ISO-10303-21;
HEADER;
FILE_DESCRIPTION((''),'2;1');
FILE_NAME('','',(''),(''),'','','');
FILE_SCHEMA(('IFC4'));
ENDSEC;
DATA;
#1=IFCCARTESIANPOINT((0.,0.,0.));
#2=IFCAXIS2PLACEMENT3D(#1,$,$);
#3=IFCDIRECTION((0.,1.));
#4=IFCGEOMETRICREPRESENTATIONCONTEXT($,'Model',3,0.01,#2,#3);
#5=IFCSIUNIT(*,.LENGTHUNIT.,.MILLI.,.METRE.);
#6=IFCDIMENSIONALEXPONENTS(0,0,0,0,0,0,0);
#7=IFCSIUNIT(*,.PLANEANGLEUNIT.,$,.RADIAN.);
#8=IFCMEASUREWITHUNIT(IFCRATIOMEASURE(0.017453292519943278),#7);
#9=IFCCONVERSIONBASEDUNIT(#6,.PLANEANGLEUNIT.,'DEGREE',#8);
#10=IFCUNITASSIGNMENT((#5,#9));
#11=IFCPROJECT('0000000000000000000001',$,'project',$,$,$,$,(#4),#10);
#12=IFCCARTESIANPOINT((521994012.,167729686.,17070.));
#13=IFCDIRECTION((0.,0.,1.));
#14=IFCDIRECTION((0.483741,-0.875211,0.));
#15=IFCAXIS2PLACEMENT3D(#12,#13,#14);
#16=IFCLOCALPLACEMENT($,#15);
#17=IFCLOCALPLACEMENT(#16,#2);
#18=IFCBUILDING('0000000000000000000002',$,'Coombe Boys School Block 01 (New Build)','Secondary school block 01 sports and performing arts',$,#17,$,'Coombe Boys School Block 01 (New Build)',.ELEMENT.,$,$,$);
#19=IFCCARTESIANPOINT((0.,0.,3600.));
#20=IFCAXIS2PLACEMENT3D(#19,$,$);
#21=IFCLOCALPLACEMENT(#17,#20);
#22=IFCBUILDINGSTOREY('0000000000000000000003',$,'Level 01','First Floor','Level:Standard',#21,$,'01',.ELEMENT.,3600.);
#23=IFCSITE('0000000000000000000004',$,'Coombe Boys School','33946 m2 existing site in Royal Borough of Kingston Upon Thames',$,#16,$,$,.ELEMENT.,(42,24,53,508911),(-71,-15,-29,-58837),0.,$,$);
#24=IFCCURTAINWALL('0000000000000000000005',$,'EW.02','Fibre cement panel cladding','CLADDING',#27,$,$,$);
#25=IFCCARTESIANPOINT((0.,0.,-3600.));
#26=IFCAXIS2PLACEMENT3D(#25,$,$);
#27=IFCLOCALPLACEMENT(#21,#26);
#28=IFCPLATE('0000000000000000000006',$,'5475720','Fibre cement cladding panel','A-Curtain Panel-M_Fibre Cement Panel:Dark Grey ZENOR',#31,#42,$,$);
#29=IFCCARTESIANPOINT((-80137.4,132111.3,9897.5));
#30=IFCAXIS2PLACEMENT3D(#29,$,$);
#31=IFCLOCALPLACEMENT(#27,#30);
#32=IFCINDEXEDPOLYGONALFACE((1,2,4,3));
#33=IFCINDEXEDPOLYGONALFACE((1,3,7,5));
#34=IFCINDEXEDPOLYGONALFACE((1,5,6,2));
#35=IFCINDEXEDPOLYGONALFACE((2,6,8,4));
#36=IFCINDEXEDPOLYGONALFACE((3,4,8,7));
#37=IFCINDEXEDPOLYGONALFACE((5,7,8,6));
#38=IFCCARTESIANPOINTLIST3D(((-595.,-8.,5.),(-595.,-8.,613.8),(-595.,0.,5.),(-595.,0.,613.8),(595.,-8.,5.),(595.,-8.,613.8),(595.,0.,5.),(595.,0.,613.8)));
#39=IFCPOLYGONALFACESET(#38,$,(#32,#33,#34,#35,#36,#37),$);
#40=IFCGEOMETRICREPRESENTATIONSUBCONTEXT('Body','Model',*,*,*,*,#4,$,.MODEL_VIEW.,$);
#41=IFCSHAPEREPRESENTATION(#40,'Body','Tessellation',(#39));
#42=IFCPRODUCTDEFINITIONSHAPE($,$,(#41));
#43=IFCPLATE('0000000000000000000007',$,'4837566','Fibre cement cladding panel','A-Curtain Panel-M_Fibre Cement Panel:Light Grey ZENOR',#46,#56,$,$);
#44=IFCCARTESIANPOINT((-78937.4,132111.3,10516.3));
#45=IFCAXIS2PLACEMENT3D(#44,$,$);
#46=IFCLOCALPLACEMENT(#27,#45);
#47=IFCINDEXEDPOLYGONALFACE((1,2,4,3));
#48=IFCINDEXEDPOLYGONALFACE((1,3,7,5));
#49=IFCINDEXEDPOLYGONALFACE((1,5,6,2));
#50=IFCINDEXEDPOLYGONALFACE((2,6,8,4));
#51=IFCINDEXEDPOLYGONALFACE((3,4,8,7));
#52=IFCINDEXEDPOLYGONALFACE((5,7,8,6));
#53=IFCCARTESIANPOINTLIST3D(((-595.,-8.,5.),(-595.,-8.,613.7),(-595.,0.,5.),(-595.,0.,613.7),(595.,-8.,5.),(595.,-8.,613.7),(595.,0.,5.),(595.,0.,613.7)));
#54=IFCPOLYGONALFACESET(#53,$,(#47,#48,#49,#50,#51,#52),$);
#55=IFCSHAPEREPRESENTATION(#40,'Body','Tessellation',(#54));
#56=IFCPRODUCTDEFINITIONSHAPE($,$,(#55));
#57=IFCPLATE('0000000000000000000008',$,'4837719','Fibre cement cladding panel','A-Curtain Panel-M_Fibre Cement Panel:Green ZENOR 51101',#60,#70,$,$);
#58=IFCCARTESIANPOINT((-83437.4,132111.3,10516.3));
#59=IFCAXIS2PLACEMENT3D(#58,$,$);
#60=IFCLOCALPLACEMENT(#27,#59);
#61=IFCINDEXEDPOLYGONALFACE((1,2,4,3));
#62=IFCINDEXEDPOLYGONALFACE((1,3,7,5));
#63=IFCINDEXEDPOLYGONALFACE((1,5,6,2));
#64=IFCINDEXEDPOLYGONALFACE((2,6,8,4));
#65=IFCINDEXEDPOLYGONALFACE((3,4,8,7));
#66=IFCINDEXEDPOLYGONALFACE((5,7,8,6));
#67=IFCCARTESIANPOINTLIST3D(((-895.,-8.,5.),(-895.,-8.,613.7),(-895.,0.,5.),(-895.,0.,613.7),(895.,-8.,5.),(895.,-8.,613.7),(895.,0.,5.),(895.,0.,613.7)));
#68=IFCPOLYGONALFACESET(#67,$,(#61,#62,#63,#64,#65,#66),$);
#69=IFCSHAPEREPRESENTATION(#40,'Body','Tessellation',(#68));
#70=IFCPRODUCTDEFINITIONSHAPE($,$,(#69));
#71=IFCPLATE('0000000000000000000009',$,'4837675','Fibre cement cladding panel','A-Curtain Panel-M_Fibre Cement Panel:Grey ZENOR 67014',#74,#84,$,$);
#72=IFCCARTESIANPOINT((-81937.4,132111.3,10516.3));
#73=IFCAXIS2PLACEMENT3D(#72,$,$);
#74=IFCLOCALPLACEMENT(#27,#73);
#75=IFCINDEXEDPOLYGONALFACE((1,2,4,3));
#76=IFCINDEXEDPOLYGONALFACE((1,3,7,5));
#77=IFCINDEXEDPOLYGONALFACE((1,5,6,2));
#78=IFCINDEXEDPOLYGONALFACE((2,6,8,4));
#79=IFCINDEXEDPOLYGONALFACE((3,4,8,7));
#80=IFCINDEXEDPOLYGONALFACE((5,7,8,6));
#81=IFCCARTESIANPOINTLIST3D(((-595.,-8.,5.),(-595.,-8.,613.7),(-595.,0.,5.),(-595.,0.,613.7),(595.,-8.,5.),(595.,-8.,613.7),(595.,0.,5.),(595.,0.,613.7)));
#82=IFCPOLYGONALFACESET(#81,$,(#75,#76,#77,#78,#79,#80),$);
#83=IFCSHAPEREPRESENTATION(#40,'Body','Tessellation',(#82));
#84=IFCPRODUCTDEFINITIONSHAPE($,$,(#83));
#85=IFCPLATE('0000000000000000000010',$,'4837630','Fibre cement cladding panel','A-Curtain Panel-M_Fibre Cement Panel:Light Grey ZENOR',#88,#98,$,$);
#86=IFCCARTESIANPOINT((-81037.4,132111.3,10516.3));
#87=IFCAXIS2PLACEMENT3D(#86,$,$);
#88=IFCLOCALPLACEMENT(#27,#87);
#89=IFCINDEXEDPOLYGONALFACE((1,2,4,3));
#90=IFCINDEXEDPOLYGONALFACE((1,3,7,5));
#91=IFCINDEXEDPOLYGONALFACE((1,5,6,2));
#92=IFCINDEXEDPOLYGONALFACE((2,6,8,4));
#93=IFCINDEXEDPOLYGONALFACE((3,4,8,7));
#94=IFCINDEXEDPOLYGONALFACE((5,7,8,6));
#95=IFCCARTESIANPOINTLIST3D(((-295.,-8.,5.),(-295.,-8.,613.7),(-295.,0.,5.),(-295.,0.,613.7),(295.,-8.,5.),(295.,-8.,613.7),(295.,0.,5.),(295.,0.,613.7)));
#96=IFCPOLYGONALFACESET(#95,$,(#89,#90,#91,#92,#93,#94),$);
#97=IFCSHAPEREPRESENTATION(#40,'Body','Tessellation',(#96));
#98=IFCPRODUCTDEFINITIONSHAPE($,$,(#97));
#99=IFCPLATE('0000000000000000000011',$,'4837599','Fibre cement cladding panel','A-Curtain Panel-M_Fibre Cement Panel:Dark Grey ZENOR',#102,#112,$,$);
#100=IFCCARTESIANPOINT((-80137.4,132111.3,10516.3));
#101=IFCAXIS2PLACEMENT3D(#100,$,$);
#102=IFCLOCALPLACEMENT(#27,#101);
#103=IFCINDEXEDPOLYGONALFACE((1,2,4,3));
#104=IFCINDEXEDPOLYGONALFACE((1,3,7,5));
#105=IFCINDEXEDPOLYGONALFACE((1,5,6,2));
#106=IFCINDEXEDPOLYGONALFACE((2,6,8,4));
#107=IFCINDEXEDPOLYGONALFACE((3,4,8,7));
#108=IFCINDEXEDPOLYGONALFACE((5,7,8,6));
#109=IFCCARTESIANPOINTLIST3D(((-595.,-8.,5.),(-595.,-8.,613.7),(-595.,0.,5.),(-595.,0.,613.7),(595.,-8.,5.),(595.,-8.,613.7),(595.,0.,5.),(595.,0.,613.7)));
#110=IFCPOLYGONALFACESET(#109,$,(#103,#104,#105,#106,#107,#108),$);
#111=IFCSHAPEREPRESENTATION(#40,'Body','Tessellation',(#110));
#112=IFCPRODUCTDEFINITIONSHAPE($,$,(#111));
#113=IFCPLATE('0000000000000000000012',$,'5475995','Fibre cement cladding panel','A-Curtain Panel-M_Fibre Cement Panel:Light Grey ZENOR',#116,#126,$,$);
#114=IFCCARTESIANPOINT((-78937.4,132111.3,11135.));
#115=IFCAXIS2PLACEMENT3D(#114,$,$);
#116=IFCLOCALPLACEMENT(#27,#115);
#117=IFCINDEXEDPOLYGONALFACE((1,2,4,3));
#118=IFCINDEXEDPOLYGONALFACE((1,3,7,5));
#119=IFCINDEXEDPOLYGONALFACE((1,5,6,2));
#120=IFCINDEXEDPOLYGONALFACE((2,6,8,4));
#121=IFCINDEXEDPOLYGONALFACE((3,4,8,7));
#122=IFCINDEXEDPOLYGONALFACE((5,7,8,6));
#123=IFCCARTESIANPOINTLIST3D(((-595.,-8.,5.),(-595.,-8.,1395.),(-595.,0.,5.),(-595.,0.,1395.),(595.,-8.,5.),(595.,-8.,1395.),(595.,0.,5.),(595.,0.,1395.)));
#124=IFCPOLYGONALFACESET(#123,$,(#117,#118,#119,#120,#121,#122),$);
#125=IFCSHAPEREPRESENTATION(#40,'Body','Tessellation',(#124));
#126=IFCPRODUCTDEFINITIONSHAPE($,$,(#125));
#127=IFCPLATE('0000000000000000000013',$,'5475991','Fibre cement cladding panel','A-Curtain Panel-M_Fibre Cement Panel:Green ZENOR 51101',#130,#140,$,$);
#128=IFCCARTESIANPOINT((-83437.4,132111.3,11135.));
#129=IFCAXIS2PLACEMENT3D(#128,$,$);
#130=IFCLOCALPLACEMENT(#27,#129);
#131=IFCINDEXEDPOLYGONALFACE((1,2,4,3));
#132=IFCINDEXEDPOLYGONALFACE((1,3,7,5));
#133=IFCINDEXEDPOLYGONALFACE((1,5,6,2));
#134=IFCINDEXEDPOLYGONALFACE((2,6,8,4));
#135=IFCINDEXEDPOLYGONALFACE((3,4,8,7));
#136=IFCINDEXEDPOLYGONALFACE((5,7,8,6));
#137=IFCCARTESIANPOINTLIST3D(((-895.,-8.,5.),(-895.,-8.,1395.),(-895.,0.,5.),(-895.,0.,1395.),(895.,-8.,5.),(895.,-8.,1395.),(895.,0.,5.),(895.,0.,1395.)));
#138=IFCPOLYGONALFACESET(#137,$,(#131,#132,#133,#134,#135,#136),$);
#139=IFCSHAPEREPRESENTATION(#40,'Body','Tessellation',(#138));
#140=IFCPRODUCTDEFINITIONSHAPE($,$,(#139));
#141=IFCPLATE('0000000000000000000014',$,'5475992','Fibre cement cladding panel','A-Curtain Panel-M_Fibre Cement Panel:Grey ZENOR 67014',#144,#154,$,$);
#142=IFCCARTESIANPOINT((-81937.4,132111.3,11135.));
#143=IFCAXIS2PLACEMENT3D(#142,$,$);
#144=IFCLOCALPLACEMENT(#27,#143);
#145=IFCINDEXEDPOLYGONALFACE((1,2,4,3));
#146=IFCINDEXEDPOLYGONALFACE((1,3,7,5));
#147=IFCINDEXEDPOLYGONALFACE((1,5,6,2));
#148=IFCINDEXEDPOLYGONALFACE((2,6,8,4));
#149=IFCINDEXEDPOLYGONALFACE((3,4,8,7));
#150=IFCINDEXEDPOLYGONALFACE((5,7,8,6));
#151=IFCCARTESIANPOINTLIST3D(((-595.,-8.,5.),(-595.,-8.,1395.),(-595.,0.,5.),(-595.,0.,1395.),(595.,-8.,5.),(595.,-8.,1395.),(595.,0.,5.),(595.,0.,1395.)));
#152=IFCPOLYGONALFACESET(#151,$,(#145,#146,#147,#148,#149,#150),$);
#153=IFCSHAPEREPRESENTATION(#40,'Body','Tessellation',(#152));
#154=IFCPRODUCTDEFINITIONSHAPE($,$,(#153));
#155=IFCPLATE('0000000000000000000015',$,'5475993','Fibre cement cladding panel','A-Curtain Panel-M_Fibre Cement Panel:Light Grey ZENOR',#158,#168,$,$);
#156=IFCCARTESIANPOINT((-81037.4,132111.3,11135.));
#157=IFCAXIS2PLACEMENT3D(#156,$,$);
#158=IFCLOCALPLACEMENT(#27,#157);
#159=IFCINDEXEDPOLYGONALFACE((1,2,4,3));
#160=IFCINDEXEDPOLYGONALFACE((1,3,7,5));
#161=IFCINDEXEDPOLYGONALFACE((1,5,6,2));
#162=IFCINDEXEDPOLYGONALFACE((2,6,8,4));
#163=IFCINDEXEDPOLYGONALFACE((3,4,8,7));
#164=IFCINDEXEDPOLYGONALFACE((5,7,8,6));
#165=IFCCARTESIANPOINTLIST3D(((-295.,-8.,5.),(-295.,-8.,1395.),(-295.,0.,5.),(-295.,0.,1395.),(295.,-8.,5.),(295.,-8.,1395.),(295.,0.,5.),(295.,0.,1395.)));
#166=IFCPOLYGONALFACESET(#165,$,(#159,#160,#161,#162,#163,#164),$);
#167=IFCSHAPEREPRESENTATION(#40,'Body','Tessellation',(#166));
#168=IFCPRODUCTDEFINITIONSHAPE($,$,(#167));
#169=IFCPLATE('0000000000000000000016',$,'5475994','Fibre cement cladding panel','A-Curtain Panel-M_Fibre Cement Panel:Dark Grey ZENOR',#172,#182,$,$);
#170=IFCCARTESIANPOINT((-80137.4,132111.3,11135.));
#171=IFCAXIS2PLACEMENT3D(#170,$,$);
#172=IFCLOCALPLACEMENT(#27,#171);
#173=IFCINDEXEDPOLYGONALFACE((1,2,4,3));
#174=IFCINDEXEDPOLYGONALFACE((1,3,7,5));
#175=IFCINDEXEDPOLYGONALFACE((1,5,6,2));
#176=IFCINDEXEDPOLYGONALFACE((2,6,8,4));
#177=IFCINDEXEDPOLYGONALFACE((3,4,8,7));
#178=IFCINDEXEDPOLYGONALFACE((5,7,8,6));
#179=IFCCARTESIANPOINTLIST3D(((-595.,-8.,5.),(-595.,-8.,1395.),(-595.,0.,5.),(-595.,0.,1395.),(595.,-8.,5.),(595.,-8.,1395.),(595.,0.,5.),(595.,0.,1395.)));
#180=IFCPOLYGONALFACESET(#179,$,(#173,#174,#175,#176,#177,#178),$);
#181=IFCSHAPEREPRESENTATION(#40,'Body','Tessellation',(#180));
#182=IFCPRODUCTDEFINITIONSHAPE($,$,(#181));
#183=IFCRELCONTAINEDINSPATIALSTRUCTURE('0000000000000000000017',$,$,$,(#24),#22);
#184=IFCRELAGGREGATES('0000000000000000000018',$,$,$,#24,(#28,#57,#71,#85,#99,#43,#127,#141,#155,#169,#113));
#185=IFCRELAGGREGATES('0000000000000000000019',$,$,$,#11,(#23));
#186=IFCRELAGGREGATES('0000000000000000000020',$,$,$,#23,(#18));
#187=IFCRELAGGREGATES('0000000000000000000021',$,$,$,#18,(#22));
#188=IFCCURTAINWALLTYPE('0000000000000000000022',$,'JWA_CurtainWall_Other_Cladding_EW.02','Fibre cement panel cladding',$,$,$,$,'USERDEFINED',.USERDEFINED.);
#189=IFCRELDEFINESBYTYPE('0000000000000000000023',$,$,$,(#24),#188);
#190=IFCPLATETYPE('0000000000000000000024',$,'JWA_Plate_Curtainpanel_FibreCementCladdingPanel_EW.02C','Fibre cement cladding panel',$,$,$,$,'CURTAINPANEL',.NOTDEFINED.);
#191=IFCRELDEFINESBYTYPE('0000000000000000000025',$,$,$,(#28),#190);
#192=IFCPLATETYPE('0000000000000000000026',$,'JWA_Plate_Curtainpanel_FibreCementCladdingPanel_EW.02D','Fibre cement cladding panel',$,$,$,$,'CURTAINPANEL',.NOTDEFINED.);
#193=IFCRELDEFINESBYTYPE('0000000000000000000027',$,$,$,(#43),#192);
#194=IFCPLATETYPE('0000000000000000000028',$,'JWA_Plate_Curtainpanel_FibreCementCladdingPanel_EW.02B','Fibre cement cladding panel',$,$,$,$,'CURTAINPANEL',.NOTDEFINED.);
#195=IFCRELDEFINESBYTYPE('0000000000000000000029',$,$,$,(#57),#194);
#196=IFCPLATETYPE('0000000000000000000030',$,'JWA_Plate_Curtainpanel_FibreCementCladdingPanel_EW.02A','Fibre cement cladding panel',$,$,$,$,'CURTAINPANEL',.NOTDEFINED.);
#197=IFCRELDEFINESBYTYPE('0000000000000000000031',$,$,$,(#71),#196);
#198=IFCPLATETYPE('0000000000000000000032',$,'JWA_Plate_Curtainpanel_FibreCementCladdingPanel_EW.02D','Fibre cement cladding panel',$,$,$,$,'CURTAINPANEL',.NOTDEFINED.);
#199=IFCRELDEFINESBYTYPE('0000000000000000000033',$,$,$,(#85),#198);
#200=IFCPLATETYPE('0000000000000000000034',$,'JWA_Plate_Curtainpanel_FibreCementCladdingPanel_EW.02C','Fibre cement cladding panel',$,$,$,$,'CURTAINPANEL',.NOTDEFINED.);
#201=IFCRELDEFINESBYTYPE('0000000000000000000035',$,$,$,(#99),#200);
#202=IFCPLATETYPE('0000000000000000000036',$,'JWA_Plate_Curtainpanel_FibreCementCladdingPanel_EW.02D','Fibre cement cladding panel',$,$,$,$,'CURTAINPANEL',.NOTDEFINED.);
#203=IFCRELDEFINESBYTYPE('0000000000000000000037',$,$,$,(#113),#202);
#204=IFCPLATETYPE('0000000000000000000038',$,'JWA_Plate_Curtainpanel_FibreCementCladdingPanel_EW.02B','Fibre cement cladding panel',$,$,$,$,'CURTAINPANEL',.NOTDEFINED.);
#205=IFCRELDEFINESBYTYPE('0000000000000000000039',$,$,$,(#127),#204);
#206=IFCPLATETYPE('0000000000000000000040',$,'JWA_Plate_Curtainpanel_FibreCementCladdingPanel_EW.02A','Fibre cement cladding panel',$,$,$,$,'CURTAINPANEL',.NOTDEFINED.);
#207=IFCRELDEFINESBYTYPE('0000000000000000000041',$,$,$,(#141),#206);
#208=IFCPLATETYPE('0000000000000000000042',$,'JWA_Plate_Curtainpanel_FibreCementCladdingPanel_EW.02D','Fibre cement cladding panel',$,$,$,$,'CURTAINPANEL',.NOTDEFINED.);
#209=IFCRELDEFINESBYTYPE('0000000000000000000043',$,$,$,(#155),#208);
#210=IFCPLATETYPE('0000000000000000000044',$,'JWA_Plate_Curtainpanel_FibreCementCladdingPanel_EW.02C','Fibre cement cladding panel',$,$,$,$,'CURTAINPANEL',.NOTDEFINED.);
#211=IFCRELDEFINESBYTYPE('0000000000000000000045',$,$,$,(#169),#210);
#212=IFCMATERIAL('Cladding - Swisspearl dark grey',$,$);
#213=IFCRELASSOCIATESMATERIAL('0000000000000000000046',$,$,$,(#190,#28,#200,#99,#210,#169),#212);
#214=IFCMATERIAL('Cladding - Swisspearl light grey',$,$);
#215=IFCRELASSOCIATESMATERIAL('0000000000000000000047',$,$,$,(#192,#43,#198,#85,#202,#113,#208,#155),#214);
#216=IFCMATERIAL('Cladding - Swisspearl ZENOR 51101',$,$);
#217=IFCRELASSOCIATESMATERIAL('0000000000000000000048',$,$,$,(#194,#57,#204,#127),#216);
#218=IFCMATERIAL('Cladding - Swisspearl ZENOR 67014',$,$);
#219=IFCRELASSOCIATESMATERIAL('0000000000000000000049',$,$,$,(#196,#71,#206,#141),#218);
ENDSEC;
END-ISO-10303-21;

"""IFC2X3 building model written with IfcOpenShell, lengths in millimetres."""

from ifc_helpers import new_model, entity, si_unit, converted_unit, direction, frame, origin, origin_2d_with_axis, place, context, subcontext, project, spatial, rectangle, extrude, source, transform, mapped, material, type_object, type_shapes, element, aggregate, save


model = new_model("IFC2X3")

# Units and contexts
model_context = context("Model", 3, precision=0.01, world=origin(), true_north=direction((0.0, 1.0)))
body_context = subcontext(model_context, "Body", "Model", "MODEL_VIEW")
ifc_project = project(units=[si_unit("LENGTHUNIT", "METRE", prefix="MILLI"), converted_unit("PLANEANGLEUNIT", "DEGREE", entity("IfcRatioMeasure", 0.017453292519943278), si_unit("PLANEANGLEUNIT", "RADIAN"), dimensions=[0, 0, 0, 0, 0, 0, 0])], contexts=[model_context])

# Site, building, storey
site_placement = place(None, frame((521994012.0, 167729686.0, 17070.0), z_axis=(0.0, 0.0, 1.0), x_axis=(0.483741, -0.875211, 0.0)))
site = spatial("IfcSite", under=ifc_project, at=site_placement, Name="Coombe Boys School", Description="33946 m2 existing site in Royal Borough of Kingston Upon Thames", CompositionType="ELEMENT", RefLatitude=(42, 24, 53, 508911), RefLongitude=(-71, -15, -29, -58837), RefElevation=0.0)
building_placement = place(site_placement, origin())
building = spatial("IfcBuilding", under=site, at=building_placement, Name="Coombe Boys School Block 01 (New Build)", Description="Secondary school block 01 sports and performing arts", LongName="Coombe Boys School Block 01 (New Build)", CompositionType="ELEMENT")
storey_placement = place(building_placement, frame((0.0, 0.0, 3600.0)))
storey = spatial("IfcBuildingStorey", under=building, at=storey_placement, Name="Level 01", Description="First Floor", ObjectType="Level:Standard", LongName="01", CompositionType="ELEMENT", Elevation=3600.0)

# Curtain wall, plates
curtain_wall_type = type_object("IfcCurtainWallType", Name="JWA_CurtainWall_Other_Cladding_EW.02", Description="Fibre cement panel cladding", ElementType="USERDEFINED", PredefinedType="USERDEFINED")
curtain_wall_placement = place(storey_placement, frame((0.0, 0.0, -3600.0)))
curtain_wall = element("IfcCurtainWall", 1, at=curtain_wall_placement, inside=storey, type_object=curtain_wall_type, Name="EW.02", Description="Fibre cement panel cladding", ObjectType="CLADDING")
ifc_material_1 = material(Name="Cladding - Swisspearl light grey")
ifc_material_2 = material(Name="Cladding - Swisspearl dark grey")
ifc_material_3 = material(Name="Cladding - Swisspearl ZENOR 51101")
ifc_material_4 = material(Name="Cladding - Swisspearl ZENOR 67014")
plate_type_1 = type_object("IfcPlateType", Name="JWA_Plate_Curtainpanel_FibreCementCladdingPanel_EW.02C", Description="Fibre cement cladding panel", ElementType="CURTAINPANEL", PredefinedType="NOTDEFINED", material=ifc_material_2)
shared_shape_1 = source(origin(), body_context, "Body", "SweptSolid", [
    extrude(rectangle(XDim=1190.0, YDim=8.0, at=origin_2d_with_axis()), frame((0.0, -4.0, 5.0), z_axis=(0.0, 0.0, 1.0), x_axis=(-1.0, 0.0, 0.0)), (0.0, 0.0, 1.0), 608.8),
])
type_shapes(plate_type_1, [shared_shape_1])
plate_1_placement = place(curtain_wall_placement, frame((-80137.4, 132111.3, 9897.5)))
plate_1 = element("IfcPlate", 2, at=plate_1_placement, type_object=plate_type_1, material=ifc_material_2, Name="5475720", Description="Fibre cement cladding panel", ObjectType="A-Curtain Panel-M_Fibre Cement Panel:Dark Grey ZENOR", context=body_context, shape_type="MappedRepresentation", body=[
    mapped(shared_shape_1, transform((0.0, 0.0, 0.0), scale=1.0)),
])
plate_type_2 = type_object("IfcPlateType", Name="JWA_Plate_Curtainpanel_FibreCementCladdingPanel_EW.02D", Description="Fibre cement cladding panel", ElementType="CURTAINPANEL", PredefinedType="NOTDEFINED", material=ifc_material_1)
shared_shape_2 = source(origin(), body_context, "Body", "SweptSolid", [
    extrude(rectangle(XDim=1190.0, YDim=8.0, at=origin_2d_with_axis()), frame((0.0, -4.0, 5.0), z_axis=(0.0, 0.0, 1.0), x_axis=(-1.0, 0.0, 0.0)), (0.0, 0.0, 1.0), 608.8),
])
type_shapes(plate_type_2, [shared_shape_2])
plate_2_placement = place(curtain_wall_placement, frame((-78937.4, 132111.3, 10516.3)))
plate_2 = element("IfcPlate", 3, at=plate_2_placement, type_object=plate_type_2, material=ifc_material_1, Name="4837566", Description="Fibre cement cladding panel", ObjectType="A-Curtain Panel-M_Fibre Cement Panel:Light Grey ZENOR", context=body_context, shape_type="MappedRepresentation", body=[
    mapped(shared_shape_2, transform((0.0, 0.0, 0.0), scale=1.0)),
])
plate_type_3 = type_object("IfcPlateType", Name="JWA_Plate_Curtainpanel_FibreCementCladdingPanel_EW.02B", Description="Fibre cement cladding panel", ElementType="CURTAINPANEL", PredefinedType="NOTDEFINED", material=ifc_material_3)
shared_shape_3 = source(origin(), body_context, "Body", "SweptSolid", [
    extrude(rectangle(XDim=1790.0, YDim=8.0, at=origin_2d_with_axis()), frame((0.0, -4.0, 5.0), z_axis=(0.0, 0.0, 1.0), x_axis=(-1.0, 0.0, 0.0)), (0.0, 0.0, 1.0), 608.8),
])
type_shapes(plate_type_3, [shared_shape_3])
plate_3_placement = place(curtain_wall_placement, frame((-83437.4, 132111.3, 10516.3)))
plate_3 = element("IfcPlate", 4, at=plate_3_placement, type_object=plate_type_3, material=ifc_material_3, Name="4837719", Description="Fibre cement cladding panel", ObjectType="A-Curtain Panel-M_Fibre Cement Panel:Green ZENOR 51101", context=body_context, shape_type="MappedRepresentation", body=[
    mapped(shared_shape_3, transform((0.0, 0.0, 0.0), scale=1.0)),
])
plate_type_4 = type_object("IfcPlateType", Name="JWA_Plate_Curtainpanel_FibreCementCladdingPanel_EW.02A", Description="Fibre cement cladding panel", ElementType="CURTAINPANEL", PredefinedType="NOTDEFINED", material=ifc_material_4)
shared_shape_4 = source(origin(), body_context, "Body", "SweptSolid", [
    extrude(rectangle(XDim=1190.0, YDim=8.0, at=origin_2d_with_axis()), frame((0.0, -4.0, 5.0), z_axis=(0.0, 0.0, 1.0), x_axis=(-1.0, 0.0, 0.0)), (0.0, 0.0, 1.0), 608.8),
])
type_shapes(plate_type_4, [shared_shape_4])
plate_4_placement = place(curtain_wall_placement, frame((-81937.4, 132111.3, 10516.3)))
plate_4 = element("IfcPlate", 5, at=plate_4_placement, type_object=plate_type_4, material=ifc_material_4, Name="4837675", Description="Fibre cement cladding panel", ObjectType="A-Curtain Panel-M_Fibre Cement Panel:Grey ZENOR 67014", context=body_context, shape_type="MappedRepresentation", body=[
    mapped(shared_shape_4, transform((0.0, 0.0, 0.0), scale=1.0)),
])
plate_type_5 = type_object("IfcPlateType", Name="JWA_Plate_Curtainpanel_FibreCementCladdingPanel_EW.02D", Description="Fibre cement cladding panel", ElementType="CURTAINPANEL", PredefinedType="NOTDEFINED", material=ifc_material_1)
shared_shape_5 = source(origin(), body_context, "Body", "SweptSolid", [
    extrude(rectangle(XDim=590.0, YDim=8.0, at=origin_2d_with_axis()), frame((0.0, -4.0, 5.0), z_axis=(0.0, 0.0, 1.0), x_axis=(-1.0, 0.0, 0.0)), (0.0, 0.0, 1.0), 608.8),
])
type_shapes(plate_type_5, [shared_shape_5])
plate_5_placement = place(curtain_wall_placement, frame((-81037.4, 132111.3, 10516.3)))
plate_5 = element("IfcPlate", 6, at=plate_5_placement, type_object=plate_type_5, material=ifc_material_1, Name="4837630", Description="Fibre cement cladding panel", ObjectType="A-Curtain Panel-M_Fibre Cement Panel:Light Grey ZENOR", context=body_context, shape_type="MappedRepresentation", body=[
    mapped(shared_shape_5, transform((0.0, 0.0, 0.0), scale=1.0)),
])
plate_type_6 = type_object("IfcPlateType", Name="JWA_Plate_Curtainpanel_FibreCementCladdingPanel_EW.02C", Description="Fibre cement cladding panel", ElementType="CURTAINPANEL", PredefinedType="NOTDEFINED", material=ifc_material_2)
shared_shape_6 = source(origin(), body_context, "Body", "SweptSolid", [
    extrude(rectangle(XDim=1190.0, YDim=8.0, at=origin_2d_with_axis()), frame((0.0, -4.0, 5.0), z_axis=(0.0, 0.0, 1.0), x_axis=(-1.0, 0.0, 0.0)), (0.0, 0.0, 1.0), 608.8),
])
type_shapes(plate_type_6, [shared_shape_6])
plate_6_placement = place(curtain_wall_placement, frame((-80137.4, 132111.3, 10516.3)))
plate_6 = element("IfcPlate", 7, at=plate_6_placement, type_object=plate_type_6, material=ifc_material_2, Name="4837599", Description="Fibre cement cladding panel", ObjectType="A-Curtain Panel-M_Fibre Cement Panel:Dark Grey ZENOR", context=body_context, shape_type="MappedRepresentation", body=[
    mapped(shared_shape_6, transform((0.0, 0.0, 0.0), scale=1.0)),
])
plate_type_7 = type_object("IfcPlateType", Name="JWA_Plate_Curtainpanel_FibreCementCladdingPanel_EW.02D", Description="Fibre cement cladding panel", ElementType="CURTAINPANEL", PredefinedType="NOTDEFINED", material=ifc_material_1)
shared_shape_7 = source(origin(), body_context, "Body", "SweptSolid", [
    extrude(rectangle(XDim=1190.0, YDim=8.0, at=origin_2d_with_axis()), frame((0.0, -4.0, 5.0), z_axis=(0.0, 0.0, 1.0), x_axis=(-1.0, 0.0, 0.0)), (0.0, 0.0, 1.0), 1390.0),
])
type_shapes(plate_type_7, [shared_shape_7])
plate_7_placement = place(curtain_wall_placement, frame((-78937.4, 132111.3, 11135.0)))
plate_7 = element("IfcPlate", 8, at=plate_7_placement, type_object=plate_type_7, material=ifc_material_1, Name="5475995", Description="Fibre cement cladding panel", ObjectType="A-Curtain Panel-M_Fibre Cement Panel:Light Grey ZENOR", context=body_context, shape_type="MappedRepresentation", body=[
    mapped(shared_shape_7, transform((0.0, 0.0, 0.0), scale=1.0)),
])
plate_type_8 = type_object("IfcPlateType", Name="JWA_Plate_Curtainpanel_FibreCementCladdingPanel_EW.02B", Description="Fibre cement cladding panel", ElementType="CURTAINPANEL", PredefinedType="NOTDEFINED", material=ifc_material_3)
shared_shape_8 = source(origin(), body_context, "Body", "SweptSolid", [
    extrude(rectangle(XDim=1790.0, YDim=8.0, at=origin_2d_with_axis()), frame((0.0, -4.0, 5.0), z_axis=(0.0, 0.0, 1.0), x_axis=(-1.0, 0.0, 0.0)), (0.0, 0.0, 1.0), 1390.0),
])
type_shapes(plate_type_8, [shared_shape_8])
plate_8_placement = place(curtain_wall_placement, frame((-83437.4, 132111.3, 11135.0)))
plate_8 = element("IfcPlate", 9, at=plate_8_placement, type_object=plate_type_8, material=ifc_material_3, Name="5475991", Description="Fibre cement cladding panel", ObjectType="A-Curtain Panel-M_Fibre Cement Panel:Green ZENOR 51101", context=body_context, shape_type="MappedRepresentation", body=[
    mapped(shared_shape_8, transform((0.0, 0.0, 0.0), scale=1.0)),
])
plate_type_9 = type_object("IfcPlateType", Name="JWA_Plate_Curtainpanel_FibreCementCladdingPanel_EW.02A", Description="Fibre cement cladding panel", ElementType="CURTAINPANEL", PredefinedType="NOTDEFINED", material=ifc_material_4)
shared_shape_9 = source(origin(), body_context, "Body", "SweptSolid", [
    extrude(rectangle(XDim=1190.0, YDim=8.0, at=origin_2d_with_axis()), frame((0.0, -4.0, 5.0), z_axis=(0.0, 0.0, 1.0), x_axis=(-1.0, 0.0, 0.0)), (0.0, 0.0, 1.0), 1390.0),
])
type_shapes(plate_type_9, [shared_shape_9])
plate_9_placement = place(curtain_wall_placement, frame((-81937.4, 132111.3, 11135.0)))
plate_9 = element("IfcPlate", 10, at=plate_9_placement, type_object=plate_type_9, material=ifc_material_4, Name="5475992", Description="Fibre cement cladding panel", ObjectType="A-Curtain Panel-M_Fibre Cement Panel:Grey ZENOR 67014", context=body_context, shape_type="MappedRepresentation", body=[
    mapped(shared_shape_9, transform((0.0, 0.0, 0.0), scale=1.0)),
])
plate_type_10 = type_object("IfcPlateType", Name="JWA_Plate_Curtainpanel_FibreCementCladdingPanel_EW.02D", Description="Fibre cement cladding panel", ElementType="CURTAINPANEL", PredefinedType="NOTDEFINED", material=ifc_material_1)
shared_shape_10 = source(origin(), body_context, "Body", "SweptSolid", [
    extrude(rectangle(XDim=590.0, YDim=8.0, at=origin_2d_with_axis()), frame((0.0, -4.0, 5.0), z_axis=(0.0, 0.0, 1.0), x_axis=(-1.0, 0.0, 0.0)), (0.0, 0.0, 1.0), 1390.0),
])
type_shapes(plate_type_10, [shared_shape_10])
plate_10_placement = place(curtain_wall_placement, frame((-81037.4, 132111.3, 11135.0)))
plate_10 = element("IfcPlate", 11, at=plate_10_placement, type_object=plate_type_10, material=ifc_material_1, Name="5475993", Description="Fibre cement cladding panel", ObjectType="A-Curtain Panel-M_Fibre Cement Panel:Light Grey ZENOR", context=body_context, shape_type="MappedRepresentation", body=[
    mapped(shared_shape_10, transform((0.0, 0.0, 0.0), scale=1.0)),
])
plate_type_11 = type_object("IfcPlateType", Name="JWA_Plate_Curtainpanel_FibreCementCladdingPanel_EW.02C", Description="Fibre cement cladding panel", ElementType="CURTAINPANEL", PredefinedType="NOTDEFINED", material=ifc_material_2)
shared_shape_11 = source(origin(), body_context, "Body", "SweptSolid", [
    extrude(rectangle(XDim=1190.0, YDim=8.0, at=origin_2d_with_axis()), frame((0.0, -4.0, 5.0), z_axis=(0.0, 0.0, 1.0), x_axis=(-1.0, 0.0, 0.0)), (0.0, 0.0, 1.0), 1390.0),
])
type_shapes(plate_type_11, [shared_shape_11])
plate_11_placement = place(curtain_wall_placement, frame((-80137.4, 132111.3, 11135.0)))
plate_11 = element("IfcPlate", 12, at=plate_11_placement, type_object=plate_type_11, material=ifc_material_2, Name="5475994", Description="Fibre cement cladding panel", ObjectType="A-Curtain Panel-M_Fibre Cement Panel:Dark Grey ZENOR", context=body_context, shape_type="MappedRepresentation", body=[
    mapped(shared_shape_11, transform((0.0, 0.0, 0.0), scale=1.0)),
])
aggregate(curtain_wall, [plate_1, plate_3, plate_4, plate_5, plate_6, plate_2, plate_8, plate_9, plate_10, plate_11, plate_7])

save(model, "model.ifc")
